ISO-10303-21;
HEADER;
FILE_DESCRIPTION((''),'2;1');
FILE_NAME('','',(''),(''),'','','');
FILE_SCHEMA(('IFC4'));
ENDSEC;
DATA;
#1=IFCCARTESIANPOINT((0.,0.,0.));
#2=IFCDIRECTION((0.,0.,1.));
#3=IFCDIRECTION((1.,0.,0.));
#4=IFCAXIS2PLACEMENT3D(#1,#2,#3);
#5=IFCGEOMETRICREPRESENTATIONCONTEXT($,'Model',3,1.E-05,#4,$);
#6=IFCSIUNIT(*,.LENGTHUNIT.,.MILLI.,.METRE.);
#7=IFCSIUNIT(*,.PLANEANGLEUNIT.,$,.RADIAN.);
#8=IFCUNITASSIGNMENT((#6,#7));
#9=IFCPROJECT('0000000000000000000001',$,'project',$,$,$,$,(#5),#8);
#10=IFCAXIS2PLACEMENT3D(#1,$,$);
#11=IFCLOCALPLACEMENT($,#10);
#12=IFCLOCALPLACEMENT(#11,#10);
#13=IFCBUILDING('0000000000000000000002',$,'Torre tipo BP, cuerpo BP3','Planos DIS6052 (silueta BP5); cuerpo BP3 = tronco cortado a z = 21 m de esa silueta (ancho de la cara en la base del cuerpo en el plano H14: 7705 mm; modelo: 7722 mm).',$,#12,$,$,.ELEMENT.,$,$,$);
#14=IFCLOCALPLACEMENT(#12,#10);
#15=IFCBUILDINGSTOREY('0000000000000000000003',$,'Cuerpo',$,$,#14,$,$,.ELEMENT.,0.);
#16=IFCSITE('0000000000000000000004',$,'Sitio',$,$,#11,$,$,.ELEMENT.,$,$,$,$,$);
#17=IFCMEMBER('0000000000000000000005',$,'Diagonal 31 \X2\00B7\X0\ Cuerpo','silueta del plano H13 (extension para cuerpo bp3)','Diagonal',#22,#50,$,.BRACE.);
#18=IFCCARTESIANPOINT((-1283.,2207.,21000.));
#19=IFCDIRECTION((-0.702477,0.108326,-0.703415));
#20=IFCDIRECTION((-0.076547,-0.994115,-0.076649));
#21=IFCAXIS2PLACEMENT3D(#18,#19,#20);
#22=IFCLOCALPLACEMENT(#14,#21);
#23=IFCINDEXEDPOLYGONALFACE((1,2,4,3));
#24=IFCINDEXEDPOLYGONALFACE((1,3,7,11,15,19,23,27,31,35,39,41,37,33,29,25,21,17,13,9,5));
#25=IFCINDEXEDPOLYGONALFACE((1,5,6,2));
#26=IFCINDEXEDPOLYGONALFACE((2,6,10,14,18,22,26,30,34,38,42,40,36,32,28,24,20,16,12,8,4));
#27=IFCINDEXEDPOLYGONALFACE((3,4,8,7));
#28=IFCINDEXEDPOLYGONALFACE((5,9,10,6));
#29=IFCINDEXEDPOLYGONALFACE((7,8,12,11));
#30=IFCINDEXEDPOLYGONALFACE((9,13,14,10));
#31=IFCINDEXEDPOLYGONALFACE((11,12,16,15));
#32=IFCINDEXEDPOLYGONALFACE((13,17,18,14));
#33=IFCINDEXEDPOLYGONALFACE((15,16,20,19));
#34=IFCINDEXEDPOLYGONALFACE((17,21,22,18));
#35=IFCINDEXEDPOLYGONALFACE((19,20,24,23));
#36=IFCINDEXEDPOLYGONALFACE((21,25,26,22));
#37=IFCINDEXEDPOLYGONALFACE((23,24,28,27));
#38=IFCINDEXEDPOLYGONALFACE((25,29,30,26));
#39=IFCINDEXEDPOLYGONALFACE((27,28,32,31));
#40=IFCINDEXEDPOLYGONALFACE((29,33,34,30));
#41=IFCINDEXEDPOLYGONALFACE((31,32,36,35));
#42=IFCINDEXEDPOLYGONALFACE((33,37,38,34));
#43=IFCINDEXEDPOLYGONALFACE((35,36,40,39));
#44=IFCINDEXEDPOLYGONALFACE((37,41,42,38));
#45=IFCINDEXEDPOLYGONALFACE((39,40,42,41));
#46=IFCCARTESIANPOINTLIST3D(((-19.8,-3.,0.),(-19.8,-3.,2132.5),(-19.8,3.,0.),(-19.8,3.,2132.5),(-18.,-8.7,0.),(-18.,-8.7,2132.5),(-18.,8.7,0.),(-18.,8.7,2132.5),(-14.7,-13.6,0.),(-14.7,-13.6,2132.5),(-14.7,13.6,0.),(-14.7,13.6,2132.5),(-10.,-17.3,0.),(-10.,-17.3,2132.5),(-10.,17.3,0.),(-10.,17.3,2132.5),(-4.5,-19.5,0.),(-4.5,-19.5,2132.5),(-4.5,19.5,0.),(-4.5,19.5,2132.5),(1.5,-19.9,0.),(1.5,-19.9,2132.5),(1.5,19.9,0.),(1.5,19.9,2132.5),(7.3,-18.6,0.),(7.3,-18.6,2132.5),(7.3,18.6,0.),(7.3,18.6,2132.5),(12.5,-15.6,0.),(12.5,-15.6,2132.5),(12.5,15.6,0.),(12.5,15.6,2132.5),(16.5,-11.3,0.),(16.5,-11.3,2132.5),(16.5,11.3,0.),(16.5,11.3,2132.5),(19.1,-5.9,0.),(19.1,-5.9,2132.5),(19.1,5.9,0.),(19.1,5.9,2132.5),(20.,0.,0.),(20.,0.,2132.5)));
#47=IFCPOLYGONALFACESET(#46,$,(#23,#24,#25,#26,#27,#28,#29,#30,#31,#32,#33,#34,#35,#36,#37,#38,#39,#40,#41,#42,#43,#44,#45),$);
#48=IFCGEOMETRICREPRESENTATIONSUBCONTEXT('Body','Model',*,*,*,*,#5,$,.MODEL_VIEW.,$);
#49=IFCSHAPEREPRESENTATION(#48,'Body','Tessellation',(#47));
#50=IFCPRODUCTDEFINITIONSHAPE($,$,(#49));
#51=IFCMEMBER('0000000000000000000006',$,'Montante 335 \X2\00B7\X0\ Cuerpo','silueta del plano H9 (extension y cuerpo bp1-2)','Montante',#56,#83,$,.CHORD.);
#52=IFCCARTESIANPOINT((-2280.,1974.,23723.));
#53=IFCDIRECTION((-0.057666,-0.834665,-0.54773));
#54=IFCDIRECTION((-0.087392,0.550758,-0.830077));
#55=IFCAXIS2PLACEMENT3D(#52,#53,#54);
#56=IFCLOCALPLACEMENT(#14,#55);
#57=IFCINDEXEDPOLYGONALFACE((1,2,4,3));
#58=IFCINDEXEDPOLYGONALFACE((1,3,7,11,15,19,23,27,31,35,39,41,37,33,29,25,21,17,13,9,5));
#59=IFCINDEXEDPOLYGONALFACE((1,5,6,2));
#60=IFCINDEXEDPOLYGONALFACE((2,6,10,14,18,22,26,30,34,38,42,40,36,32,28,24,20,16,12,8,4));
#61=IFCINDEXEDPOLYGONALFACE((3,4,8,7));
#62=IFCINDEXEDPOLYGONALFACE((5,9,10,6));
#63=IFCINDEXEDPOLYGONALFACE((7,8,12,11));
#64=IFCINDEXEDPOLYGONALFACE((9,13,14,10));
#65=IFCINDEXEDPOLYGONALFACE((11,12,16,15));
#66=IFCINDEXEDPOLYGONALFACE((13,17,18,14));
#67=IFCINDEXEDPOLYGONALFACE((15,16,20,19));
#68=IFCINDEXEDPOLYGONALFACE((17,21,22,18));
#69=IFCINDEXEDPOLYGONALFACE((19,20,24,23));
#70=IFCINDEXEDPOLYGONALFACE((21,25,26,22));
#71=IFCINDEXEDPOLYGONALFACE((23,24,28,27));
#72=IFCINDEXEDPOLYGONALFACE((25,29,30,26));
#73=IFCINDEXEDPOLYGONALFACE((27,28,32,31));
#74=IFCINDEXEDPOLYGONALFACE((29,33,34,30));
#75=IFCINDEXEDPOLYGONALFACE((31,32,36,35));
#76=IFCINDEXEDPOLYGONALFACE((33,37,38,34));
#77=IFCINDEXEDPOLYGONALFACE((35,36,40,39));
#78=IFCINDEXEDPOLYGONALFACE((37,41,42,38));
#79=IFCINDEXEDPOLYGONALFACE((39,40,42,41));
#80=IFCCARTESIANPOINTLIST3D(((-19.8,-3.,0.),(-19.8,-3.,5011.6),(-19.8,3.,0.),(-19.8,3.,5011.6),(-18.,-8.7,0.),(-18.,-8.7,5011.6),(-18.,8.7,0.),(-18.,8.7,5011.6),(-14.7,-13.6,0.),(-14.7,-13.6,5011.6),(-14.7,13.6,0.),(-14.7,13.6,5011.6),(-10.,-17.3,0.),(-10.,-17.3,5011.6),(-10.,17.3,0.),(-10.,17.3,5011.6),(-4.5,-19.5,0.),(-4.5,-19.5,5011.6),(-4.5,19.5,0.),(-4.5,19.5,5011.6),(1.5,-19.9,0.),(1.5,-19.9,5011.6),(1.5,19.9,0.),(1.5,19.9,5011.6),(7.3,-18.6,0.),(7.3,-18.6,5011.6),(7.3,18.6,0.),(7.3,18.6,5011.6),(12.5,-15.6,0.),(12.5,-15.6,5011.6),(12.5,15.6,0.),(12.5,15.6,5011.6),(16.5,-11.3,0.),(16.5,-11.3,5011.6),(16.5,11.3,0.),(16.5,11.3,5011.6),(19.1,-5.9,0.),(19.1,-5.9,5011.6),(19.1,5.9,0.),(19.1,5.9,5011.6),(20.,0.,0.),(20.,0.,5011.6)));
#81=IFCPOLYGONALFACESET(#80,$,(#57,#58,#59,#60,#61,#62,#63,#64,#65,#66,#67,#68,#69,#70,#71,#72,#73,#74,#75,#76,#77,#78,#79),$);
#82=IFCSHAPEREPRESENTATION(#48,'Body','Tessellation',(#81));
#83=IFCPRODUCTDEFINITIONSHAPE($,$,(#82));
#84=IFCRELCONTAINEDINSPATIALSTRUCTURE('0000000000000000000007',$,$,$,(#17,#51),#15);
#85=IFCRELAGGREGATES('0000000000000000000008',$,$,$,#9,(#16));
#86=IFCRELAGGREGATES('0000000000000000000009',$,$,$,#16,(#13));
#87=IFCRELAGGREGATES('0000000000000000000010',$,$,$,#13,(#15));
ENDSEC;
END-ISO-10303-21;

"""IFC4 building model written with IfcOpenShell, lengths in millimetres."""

from ifc_helpers import new_model, si_unit, frame, origin, origin_with_axes, place, context, subcontext, project, spatial, circle, extrude, element, save


model = new_model("IFC4")

# Units and contexts
model_context = context("Model", 3, precision=1e-05, world=origin_with_axes())
body_context = subcontext(model_context, "Body", "Model", "MODEL_VIEW")
ifc_project = project(units=[si_unit("LENGTHUNIT", "METRE", prefix="MILLI"), si_unit("PLANEANGLEUNIT", "RADIAN")], contexts=[model_context])

# Site, building, storey
site_placement = place(None, origin())
site = spatial("IfcSite", under=ifc_project, at=site_placement, Name="Sitio", CompositionType="ELEMENT")
building_placement = place(site_placement, origin())
building = spatial("IfcBuilding", under=site, at=building_placement, Name="Torre tipo BP, cuerpo BP3", Description="Planos DIS6052 (silueta BP5); cuerpo BP3 = tronco cortado a z = 21 m de esa silueta (ancho de la cara en la base del cuerpo en el plano H14: 7705 mm; modelo: 7722 mm).", CompositionType="ELEMENT")
storey_placement = place(building_placement, origin())
storey = spatial("IfcBuildingStorey", under=building, at=storey_placement, Name="Cuerpo", CompositionType="ELEMENT", Elevation=0.0)

# Members
member_1_placement = place(storey_placement, frame((-1283.0, 2207.0, 21000.0), z_axis=(-0.702477, 0.108326, -0.703415), x_axis=(-0.076547, -0.994115, -0.076649)))
element("IfcMember", 1, at=member_1_placement, inside=storey, Name="Diagonal 31 · Cuerpo", Description="silueta del plano H13 (extension para cuerpo bp3)", ObjectType="Diagonal", PredefinedType="BRACE", context=body_context, shape_type="SweptSolid", body=[
    extrude(circle(Radius=20.0), None, (0.0, 0.0, 1.0), 2132.5),
])
member_2_placement = place(storey_placement, frame((-2280.0, 1974.0, 23723.0), z_axis=(-0.057666, -0.834665, -0.54773), x_axis=(-0.087392, 0.550758, -0.830077)))
element("IfcMember", 2, at=member_2_placement, inside=storey, Name="Montante 335 · Cuerpo", Description="silueta del plano H9 (extension y cuerpo bp1-2)", ObjectType="Montante", PredefinedType="CHORD", context=body_context, shape_type="SweptSolid", body=[
    extrude(circle(Radius=20.0), None, (0.0, 0.0, 1.0), 5011.6),
])

save(model, "model.ifc")
